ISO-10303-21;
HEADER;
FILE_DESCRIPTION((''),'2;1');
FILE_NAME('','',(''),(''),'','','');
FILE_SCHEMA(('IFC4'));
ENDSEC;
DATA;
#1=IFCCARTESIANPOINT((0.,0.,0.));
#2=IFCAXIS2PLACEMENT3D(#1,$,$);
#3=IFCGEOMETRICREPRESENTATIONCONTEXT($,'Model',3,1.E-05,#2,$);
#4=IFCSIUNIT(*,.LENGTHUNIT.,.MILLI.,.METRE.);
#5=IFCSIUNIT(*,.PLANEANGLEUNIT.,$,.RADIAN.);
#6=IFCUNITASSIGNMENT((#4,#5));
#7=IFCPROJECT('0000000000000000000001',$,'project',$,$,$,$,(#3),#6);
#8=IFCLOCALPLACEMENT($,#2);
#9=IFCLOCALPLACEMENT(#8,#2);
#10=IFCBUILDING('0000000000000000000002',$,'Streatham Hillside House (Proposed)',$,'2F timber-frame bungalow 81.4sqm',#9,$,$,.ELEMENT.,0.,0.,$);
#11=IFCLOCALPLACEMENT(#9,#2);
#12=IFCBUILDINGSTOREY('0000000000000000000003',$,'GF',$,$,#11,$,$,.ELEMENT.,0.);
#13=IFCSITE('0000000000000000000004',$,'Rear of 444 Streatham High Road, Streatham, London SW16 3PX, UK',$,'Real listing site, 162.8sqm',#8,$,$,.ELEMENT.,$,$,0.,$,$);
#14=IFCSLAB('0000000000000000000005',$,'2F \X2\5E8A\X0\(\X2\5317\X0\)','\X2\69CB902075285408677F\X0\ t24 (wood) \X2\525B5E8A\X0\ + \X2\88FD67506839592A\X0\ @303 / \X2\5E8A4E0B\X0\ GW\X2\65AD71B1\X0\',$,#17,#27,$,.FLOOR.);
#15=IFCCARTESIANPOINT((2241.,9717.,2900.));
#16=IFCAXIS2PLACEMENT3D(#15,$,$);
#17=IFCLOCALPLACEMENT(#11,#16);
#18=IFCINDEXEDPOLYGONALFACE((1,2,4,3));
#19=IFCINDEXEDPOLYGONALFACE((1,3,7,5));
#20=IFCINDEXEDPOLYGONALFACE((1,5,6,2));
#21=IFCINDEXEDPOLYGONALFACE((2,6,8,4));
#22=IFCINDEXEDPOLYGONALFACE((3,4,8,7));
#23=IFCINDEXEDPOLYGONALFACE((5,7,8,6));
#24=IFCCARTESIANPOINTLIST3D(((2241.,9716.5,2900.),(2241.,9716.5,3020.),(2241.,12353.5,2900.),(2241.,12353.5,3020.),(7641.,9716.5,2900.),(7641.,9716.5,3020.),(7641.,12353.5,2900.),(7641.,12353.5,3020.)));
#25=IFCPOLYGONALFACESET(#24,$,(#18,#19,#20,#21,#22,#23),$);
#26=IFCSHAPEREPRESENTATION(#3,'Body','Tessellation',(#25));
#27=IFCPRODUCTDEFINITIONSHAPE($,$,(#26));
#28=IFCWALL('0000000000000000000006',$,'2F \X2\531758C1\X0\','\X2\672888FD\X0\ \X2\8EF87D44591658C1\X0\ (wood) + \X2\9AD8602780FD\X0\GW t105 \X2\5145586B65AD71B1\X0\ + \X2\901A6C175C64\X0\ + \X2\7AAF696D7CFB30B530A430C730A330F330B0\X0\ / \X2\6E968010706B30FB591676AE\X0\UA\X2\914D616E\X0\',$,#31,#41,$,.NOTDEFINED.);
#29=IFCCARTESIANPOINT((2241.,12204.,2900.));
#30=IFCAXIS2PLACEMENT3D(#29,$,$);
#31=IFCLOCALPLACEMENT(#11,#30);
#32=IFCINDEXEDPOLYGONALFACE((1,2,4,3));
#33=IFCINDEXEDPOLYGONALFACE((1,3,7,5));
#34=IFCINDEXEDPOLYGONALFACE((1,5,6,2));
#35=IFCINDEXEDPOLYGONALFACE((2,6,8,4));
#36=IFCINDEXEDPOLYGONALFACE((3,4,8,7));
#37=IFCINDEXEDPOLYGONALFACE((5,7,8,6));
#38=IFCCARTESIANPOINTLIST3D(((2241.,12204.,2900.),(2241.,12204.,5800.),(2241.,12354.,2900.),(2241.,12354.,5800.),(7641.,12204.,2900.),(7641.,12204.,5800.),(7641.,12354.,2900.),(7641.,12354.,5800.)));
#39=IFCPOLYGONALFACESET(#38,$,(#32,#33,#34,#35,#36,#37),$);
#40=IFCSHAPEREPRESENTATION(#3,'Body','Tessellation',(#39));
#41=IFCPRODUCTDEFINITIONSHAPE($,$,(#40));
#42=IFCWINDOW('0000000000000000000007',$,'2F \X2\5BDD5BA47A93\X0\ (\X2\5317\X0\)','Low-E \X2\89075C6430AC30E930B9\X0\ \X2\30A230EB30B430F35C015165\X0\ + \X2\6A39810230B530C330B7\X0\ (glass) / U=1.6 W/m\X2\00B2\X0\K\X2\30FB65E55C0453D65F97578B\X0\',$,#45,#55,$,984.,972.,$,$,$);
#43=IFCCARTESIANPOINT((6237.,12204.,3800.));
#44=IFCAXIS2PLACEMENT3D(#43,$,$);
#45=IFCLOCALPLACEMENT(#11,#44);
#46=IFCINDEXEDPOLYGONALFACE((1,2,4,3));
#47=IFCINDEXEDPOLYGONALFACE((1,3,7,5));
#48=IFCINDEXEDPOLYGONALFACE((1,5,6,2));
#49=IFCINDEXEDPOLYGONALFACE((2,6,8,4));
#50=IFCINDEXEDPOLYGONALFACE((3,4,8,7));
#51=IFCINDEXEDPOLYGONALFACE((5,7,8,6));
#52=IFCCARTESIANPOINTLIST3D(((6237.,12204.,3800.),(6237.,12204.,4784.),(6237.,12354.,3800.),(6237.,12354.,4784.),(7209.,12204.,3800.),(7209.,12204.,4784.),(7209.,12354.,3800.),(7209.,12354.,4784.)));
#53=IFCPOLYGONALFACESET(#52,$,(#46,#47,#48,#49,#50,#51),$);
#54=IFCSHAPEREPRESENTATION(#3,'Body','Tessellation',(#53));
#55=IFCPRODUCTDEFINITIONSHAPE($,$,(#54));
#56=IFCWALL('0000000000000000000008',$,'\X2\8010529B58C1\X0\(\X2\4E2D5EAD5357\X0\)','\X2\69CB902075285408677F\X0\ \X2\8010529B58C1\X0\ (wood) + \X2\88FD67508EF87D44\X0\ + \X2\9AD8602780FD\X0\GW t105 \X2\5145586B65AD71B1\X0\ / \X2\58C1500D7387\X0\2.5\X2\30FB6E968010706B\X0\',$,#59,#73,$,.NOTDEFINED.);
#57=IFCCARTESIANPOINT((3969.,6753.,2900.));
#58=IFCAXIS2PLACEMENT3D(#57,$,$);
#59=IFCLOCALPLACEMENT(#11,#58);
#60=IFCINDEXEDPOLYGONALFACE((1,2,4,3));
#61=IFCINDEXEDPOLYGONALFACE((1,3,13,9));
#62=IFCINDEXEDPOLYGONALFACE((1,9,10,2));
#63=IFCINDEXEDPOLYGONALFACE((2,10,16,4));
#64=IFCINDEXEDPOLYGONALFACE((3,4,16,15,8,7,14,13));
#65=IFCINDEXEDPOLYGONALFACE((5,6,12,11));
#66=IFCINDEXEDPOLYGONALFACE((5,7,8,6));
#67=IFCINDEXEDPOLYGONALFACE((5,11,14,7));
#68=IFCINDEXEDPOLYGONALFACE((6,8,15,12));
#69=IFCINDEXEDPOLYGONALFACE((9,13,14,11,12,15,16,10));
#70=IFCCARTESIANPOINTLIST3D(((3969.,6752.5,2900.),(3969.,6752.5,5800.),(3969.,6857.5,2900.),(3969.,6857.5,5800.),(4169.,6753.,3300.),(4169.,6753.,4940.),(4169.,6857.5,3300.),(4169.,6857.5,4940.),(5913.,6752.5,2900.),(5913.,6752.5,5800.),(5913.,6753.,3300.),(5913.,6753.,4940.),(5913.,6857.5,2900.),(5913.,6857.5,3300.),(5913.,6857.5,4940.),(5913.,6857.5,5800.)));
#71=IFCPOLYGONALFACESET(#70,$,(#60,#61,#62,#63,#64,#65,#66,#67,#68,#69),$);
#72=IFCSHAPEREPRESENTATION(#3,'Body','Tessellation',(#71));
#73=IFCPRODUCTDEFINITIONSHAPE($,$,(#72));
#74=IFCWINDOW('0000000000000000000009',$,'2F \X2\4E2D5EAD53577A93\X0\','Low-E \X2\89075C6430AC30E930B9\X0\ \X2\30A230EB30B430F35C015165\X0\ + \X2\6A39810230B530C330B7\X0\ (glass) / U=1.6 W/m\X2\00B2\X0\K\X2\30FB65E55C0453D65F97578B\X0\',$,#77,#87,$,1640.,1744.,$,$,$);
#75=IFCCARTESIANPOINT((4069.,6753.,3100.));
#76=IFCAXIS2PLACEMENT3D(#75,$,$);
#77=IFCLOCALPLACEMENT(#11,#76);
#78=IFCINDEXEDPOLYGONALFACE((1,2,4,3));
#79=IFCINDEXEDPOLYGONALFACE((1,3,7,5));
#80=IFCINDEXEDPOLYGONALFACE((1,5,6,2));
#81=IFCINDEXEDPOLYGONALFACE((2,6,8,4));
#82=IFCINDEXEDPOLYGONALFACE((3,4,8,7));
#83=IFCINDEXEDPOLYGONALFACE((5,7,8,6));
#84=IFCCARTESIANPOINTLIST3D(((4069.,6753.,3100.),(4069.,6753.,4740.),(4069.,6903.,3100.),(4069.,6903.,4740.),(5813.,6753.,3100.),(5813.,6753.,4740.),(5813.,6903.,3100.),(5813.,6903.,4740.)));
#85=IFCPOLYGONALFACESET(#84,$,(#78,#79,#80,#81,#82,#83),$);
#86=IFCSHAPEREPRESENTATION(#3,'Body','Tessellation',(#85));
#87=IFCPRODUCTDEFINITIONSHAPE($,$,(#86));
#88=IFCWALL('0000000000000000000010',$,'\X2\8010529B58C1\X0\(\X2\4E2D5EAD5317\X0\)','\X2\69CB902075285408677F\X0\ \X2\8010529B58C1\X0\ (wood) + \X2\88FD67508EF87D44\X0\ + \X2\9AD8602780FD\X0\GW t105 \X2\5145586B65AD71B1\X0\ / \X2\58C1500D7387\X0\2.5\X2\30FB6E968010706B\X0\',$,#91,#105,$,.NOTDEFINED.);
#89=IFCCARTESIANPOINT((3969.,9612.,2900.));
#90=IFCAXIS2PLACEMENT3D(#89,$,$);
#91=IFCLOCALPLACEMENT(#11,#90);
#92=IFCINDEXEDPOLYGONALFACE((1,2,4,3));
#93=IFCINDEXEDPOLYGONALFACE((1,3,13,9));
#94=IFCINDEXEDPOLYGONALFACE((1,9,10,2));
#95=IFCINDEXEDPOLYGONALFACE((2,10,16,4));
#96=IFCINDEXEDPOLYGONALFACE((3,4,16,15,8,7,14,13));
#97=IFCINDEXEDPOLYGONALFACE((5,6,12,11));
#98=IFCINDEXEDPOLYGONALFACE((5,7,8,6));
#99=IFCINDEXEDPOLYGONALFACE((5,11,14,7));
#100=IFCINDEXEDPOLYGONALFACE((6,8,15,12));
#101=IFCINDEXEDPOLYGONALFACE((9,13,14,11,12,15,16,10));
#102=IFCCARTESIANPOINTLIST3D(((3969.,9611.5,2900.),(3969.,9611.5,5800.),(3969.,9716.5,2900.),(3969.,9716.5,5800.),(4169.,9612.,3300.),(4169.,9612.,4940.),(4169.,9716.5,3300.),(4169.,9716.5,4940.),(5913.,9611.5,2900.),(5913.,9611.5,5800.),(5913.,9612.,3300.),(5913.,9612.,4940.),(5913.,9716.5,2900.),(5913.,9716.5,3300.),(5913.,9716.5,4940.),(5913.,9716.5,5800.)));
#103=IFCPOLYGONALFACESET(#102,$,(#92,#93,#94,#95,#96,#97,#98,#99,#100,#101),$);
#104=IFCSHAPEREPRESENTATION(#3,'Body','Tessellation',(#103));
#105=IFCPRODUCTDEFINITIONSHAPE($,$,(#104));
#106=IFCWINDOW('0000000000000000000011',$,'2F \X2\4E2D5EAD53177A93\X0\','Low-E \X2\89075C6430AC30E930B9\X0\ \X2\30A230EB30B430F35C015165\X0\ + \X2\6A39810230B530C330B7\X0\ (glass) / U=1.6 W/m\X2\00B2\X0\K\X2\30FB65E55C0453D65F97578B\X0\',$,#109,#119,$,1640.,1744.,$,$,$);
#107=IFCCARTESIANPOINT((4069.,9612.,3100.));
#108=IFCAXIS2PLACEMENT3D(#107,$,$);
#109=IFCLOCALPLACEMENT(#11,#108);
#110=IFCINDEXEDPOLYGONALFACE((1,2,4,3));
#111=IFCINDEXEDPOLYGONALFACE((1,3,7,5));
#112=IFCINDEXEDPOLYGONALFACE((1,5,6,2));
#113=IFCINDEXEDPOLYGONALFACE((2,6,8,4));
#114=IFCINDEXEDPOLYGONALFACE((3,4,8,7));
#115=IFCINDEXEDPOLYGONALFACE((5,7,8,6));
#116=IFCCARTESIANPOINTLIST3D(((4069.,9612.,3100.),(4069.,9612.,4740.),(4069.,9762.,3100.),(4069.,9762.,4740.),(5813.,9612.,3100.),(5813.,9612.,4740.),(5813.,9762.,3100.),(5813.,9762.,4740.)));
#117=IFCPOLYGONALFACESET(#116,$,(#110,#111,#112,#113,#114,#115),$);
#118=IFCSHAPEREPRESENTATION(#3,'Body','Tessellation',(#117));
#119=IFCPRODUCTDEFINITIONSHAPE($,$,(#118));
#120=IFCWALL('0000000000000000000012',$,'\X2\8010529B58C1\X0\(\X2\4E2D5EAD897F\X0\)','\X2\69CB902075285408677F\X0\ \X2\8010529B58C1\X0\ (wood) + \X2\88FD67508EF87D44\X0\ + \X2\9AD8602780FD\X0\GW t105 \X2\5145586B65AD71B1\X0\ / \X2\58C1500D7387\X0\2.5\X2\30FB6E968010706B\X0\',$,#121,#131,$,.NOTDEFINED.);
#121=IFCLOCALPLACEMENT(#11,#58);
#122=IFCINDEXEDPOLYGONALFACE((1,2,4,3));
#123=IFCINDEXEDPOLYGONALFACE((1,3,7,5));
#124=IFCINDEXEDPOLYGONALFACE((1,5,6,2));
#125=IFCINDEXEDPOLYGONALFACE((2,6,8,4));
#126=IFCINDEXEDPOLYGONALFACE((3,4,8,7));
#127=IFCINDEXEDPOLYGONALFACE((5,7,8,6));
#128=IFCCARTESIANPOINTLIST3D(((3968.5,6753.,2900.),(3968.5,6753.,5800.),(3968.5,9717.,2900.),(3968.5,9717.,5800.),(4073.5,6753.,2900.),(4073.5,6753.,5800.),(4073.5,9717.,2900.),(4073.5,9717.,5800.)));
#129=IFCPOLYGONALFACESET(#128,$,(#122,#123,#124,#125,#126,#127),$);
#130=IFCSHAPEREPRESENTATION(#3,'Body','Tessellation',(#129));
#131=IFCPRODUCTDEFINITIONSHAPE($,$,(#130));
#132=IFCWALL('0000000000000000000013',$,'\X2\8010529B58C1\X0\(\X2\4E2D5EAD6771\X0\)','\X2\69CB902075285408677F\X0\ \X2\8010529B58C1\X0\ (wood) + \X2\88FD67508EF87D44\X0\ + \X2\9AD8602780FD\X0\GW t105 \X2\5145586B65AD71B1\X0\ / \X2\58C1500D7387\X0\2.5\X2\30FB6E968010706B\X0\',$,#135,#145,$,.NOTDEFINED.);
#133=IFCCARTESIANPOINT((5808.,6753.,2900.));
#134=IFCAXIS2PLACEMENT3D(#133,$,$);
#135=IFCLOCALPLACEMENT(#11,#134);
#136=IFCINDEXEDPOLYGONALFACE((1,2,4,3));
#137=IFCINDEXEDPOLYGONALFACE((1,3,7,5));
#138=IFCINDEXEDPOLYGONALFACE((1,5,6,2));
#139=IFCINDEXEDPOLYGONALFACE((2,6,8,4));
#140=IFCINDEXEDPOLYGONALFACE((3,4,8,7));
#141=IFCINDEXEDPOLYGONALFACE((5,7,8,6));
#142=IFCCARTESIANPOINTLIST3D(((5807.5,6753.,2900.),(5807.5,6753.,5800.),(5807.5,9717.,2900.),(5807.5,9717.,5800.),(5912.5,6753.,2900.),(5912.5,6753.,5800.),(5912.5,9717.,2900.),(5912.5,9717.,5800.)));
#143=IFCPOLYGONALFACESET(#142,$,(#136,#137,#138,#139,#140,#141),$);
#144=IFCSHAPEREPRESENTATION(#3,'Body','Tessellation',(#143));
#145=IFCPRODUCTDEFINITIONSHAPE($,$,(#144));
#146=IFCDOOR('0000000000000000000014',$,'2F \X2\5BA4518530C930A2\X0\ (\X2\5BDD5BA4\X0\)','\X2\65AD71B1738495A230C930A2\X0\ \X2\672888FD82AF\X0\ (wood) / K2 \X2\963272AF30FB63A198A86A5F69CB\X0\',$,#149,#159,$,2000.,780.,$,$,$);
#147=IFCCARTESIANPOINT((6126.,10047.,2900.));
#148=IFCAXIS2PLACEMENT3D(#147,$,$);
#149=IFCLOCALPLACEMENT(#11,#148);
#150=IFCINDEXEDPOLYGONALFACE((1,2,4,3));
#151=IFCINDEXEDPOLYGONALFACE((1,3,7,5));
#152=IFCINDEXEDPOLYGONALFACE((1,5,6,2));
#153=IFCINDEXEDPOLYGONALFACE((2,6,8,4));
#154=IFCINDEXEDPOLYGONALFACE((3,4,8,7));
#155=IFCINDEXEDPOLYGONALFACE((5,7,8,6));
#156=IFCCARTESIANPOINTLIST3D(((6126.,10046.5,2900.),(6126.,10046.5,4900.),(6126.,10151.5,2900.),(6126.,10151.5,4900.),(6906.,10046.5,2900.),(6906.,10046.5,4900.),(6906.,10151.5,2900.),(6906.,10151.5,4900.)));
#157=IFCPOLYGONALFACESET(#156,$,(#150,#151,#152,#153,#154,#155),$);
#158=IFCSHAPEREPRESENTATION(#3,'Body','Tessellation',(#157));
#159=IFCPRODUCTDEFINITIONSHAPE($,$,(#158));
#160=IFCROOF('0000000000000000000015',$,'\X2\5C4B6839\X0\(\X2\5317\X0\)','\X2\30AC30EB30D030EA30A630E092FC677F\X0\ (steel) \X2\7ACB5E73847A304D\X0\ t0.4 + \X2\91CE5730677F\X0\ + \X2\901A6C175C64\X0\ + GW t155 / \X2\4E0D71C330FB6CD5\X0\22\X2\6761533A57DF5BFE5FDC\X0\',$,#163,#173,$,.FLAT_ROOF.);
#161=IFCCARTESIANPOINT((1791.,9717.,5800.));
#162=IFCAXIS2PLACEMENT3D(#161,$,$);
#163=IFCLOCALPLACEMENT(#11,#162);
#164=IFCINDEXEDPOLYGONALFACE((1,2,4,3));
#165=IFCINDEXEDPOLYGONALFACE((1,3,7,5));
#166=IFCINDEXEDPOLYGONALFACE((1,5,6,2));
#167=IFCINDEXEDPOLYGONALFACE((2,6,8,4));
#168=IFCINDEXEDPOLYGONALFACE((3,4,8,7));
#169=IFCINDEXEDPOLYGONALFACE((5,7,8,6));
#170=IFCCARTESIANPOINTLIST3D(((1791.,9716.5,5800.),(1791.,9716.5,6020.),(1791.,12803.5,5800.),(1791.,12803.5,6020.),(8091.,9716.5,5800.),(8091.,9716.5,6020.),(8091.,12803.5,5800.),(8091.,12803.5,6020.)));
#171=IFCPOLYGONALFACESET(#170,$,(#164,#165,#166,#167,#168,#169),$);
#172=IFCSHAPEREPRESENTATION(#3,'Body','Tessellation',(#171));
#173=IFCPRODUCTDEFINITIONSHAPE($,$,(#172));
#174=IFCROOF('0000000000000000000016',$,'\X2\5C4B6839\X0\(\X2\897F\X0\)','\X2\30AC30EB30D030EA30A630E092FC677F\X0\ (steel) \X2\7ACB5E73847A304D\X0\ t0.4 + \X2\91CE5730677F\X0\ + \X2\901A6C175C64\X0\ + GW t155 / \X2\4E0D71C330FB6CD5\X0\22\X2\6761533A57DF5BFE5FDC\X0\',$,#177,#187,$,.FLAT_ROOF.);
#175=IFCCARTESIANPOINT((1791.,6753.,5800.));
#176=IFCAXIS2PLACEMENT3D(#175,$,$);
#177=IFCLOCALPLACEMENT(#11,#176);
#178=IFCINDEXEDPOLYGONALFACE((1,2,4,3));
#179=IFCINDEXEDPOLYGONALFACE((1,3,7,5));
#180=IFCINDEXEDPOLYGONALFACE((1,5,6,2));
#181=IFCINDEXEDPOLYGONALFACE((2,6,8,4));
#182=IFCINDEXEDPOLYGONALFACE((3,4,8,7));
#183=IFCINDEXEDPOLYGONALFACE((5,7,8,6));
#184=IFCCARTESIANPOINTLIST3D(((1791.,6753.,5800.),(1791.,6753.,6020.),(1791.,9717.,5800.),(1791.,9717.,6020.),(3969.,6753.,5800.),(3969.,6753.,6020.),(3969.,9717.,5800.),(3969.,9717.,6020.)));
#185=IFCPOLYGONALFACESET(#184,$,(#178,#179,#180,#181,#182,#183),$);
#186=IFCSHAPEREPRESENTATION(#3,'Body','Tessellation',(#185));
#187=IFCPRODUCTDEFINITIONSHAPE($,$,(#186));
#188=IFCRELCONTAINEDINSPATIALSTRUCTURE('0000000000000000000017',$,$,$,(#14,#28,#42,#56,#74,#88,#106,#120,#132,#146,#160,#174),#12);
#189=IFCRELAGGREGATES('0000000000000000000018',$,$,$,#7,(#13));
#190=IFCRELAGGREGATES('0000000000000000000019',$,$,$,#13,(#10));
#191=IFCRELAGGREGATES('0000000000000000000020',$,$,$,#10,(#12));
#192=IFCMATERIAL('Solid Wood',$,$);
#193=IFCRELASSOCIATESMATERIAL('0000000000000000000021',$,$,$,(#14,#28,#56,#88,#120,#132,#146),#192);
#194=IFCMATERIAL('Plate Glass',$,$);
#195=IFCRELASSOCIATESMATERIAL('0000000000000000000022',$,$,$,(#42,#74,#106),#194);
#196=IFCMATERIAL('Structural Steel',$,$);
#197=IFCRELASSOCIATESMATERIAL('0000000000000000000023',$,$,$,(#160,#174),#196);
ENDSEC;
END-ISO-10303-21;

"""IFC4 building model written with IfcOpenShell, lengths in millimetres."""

from ifc_helpers import new_model, si_unit, frame, frame_2d, origin, place, context, project, spatial, rectangle, extrude, material, element, fill, save


model = new_model("IFC4")

# Units and contexts
model_context = context("Model", 3, precision=1e-05, world=origin())
ifc_project = project(units=[si_unit("LENGTHUNIT", "METRE", prefix="MILLI"), si_unit("PLANEANGLEUNIT", "RADIAN")], contexts=[model_context])

# Site, building, storey
site_placement = place(None, origin())
site = spatial("IfcSite", under=ifc_project, at=site_placement, Name="Rear of 444 Streatham High Road, Streatham, London SW16 3PX, UK", ObjectType="Real listing site, 162.8sqm", CompositionType="ELEMENT", RefElevation=0.0)
building_placement = place(site_placement, origin())
building = spatial("IfcBuilding", under=site, at=building_placement, Name="Streatham Hillside House (Proposed)", ObjectType="2F timber-frame bungalow 81.4sqm", CompositionType="ELEMENT", ElevationOfRefHeight=0.0, ElevationOfTerrain=0.0)
storey_placement = place(building_placement, origin())
storey = spatial("IfcBuildingStorey", under=building, at=storey_placement, Name="GF", CompositionType="ELEMENT", Elevation=0.0)

# Slab
ifc_material_1 = material(Name="Solid Wood")
slab_placement = place(storey_placement, frame((2241.0, 9717.0, 2900.0)))
element("IfcSlab", 1, at=slab_placement, inside=storey, material=ifc_material_1, Name="2F 床(北)", Description="構造用合板 t24 (wood) 剛床 + 製材根太 @303 / 床下 GW断熱", PredefinedType="FLOOR", context=model_context, shape_type="SweptSolid", body=[
    extrude(rectangle(XDim=5400.0, YDim=2637.0, at=frame_2d((2700.0, 1318.0))), frame((2241.0, 9717.0, 2900.0)), (0.0, 0.0, 1.0), 120.0),
])

# Walls, openings, windows
wall_1_placement = place(storey_placement, frame((2241.0, 12204.0, 2900.0)))
wall_1 = element("IfcWall", 2, at=wall_1_placement, inside=storey, material=ifc_material_1, Name="2F 北壁", Description="木製 軸組外壁 (wood) + 高性能GW t105 充填断熱 + 通気層 + 窯業系サイディング / 準耐火・外皮UA配慮", PredefinedType="NOTDEFINED", context=model_context, shape_type="SweptSolid", body=[
    extrude(rectangle(XDim=5400.0, YDim=150.0, at=frame_2d((2700.0, 75.0))), frame((2241.0, 12204.0, 2900.0)), (0.0, 0.0, 1.0), 2900.0),
])
opening_1_placement = place(storey_placement, frame((6237.0, 12204.0, 3800.0)))
opening_1 = element("IfcOpeningElement", 3, at=opening_1_placement, cuts=wall_1, PredefinedType="NOTDEFINED", context=model_context, shape_type="SweptSolid", body=[
    extrude(rectangle(XDim=972.0, YDim=150.0, at=frame_2d((486.0, 75.0))), frame((6237.0, 12204.0, 3800.0)), (0.0, 0.0, 1.0), 984.0),
])
ifc_material_2 = material(Name="Plate Glass")
window_1_placement = place(storey_placement, frame((6237.0, 12204.0, 3800.0)))
window_1 = element("IfcWindow", 4, at=window_1_placement, inside=storey, material=ifc_material_2, Name="2F 寝室窓 (北)", Description="Low-E 複層ガラス アルゴン封入 + 樹脂サッシ (glass) / U=1.6 W/m²K・日射取得型", OverallHeight=984.0, OverallWidth=972.0, context=model_context, shape_type="SweptSolid", body=[
    extrude(rectangle(XDim=972.0, YDim=150.0, at=frame_2d((486.0, 75.0))), frame((6237.0, 12204.0, 3800.0)), (0.0, 0.0, 1.0), 984.0),
])
fill(opening_1, window_1)
wall_2_placement = place(storey_placement, frame((3969.0, 6753.0, 2900.0)))
wall_2 = element("IfcWall", 5, at=wall_2_placement, inside=storey, material=ifc_material_1, Name="耐力壁(中庭南)", Description="構造用合板 耐力壁 (wood) + 製材軸組 + 高性能GW t105 充填断熱 / 壁倍率2.5・準耐火", PredefinedType="NOTDEFINED", context=model_context, shape_type="SweptSolid", body=[
    extrude(rectangle(XDim=1944.0, YDim=105.0, at=frame_2d((972.0, 52.0))), frame((3969.0, 6753.0, 2900.0)), (0.0, 0.0, 1.0), 2900.0),
])
opening_2_placement = place(storey_placement, frame((4069.0, 6753.0, 3100.0)))
opening_2 = element("IfcOpeningElement", 6, at=opening_2_placement, cuts=wall_2, PredefinedType="NOTDEFINED", context=model_context, shape_type="SweptSolid", body=[
    extrude(rectangle(XDim=1744.0, YDim=150.0, at=frame_2d((872.0, 75.0))), frame((4069.0, 6753.0, 3100.0)), (0.0, 0.0, 1.0), 1640.0),
])
window_2_placement = place(storey_placement, frame((4069.0, 6753.0, 3100.0)))
window_2 = element("IfcWindow", 7, at=window_2_placement, inside=storey, material=ifc_material_2, Name="2F 中庭南窓", Description="Low-E 複層ガラス アルゴン封入 + 樹脂サッシ (glass) / U=1.6 W/m²K・日射取得型", OverallHeight=1640.0, OverallWidth=1744.0, context=model_context, shape_type="SweptSolid", body=[
    extrude(rectangle(XDim=1744.0, YDim=150.0, at=frame_2d((872.0, 75.0))), frame((4069.0, 6753.0, 3100.0)), (0.0, 0.0, 1.0), 1640.0),
])
fill(opening_2, window_2)
wall_3_placement = place(storey_placement, frame((3969.0, 9612.0, 2900.0)))
wall_3 = element("IfcWall", 8, at=wall_3_placement, inside=storey, material=ifc_material_1, Name="耐力壁(中庭北)", Description="構造用合板 耐力壁 (wood) + 製材軸組 + 高性能GW t105 充填断熱 / 壁倍率2.5・準耐火", PredefinedType="NOTDEFINED", context=model_context, shape_type="SweptSolid", body=[
    extrude(rectangle(XDim=1944.0, YDim=105.0, at=frame_2d((972.0, 52.0))), frame((3969.0, 9612.0, 2900.0)), (0.0, 0.0, 1.0), 2900.0),
])
opening_3_placement = place(storey_placement, frame((4069.0, 9612.0, 3100.0)))
opening_3 = element("IfcOpeningElement", 9, at=opening_3_placement, cuts=wall_3, PredefinedType="NOTDEFINED", context=model_context, shape_type="SweptSolid", body=[
    extrude(rectangle(XDim=1744.0, YDim=150.0, at=frame_2d((872.0, 75.0))), frame((4069.0, 9612.0, 3100.0)), (0.0, 0.0, 1.0), 1640.0),
])
window_3_placement = place(storey_placement, frame((4069.0, 9612.0, 3100.0)))
window_3 = element("IfcWindow", 10, at=window_3_placement, inside=storey, material=ifc_material_2, Name="2F 中庭北窓", Description="Low-E 複層ガラス アルゴン封入 + 樹脂サッシ (glass) / U=1.6 W/m²K・日射取得型", OverallHeight=1640.0, OverallWidth=1744.0, context=model_context, shape_type="SweptSolid", body=[
    extrude(rectangle(XDim=1744.0, YDim=150.0, at=frame_2d((872.0, 75.0))), frame((4069.0, 9612.0, 3100.0)), (0.0, 0.0, 1.0), 1640.0),
])
fill(opening_3, window_3)

# Walls
wall_4_placement = place(storey_placement, frame((3969.0, 6753.0, 2900.0)))
element("IfcWall", 11, at=wall_4_placement, inside=storey, material=ifc_material_1, Name="耐力壁(中庭西)", Description="構造用合板 耐力壁 (wood) + 製材軸組 + 高性能GW t105 充填断熱 / 壁倍率2.5・準耐火", PredefinedType="NOTDEFINED", context=model_context, shape_type="SweptSolid", body=[
    extrude(rectangle(XDim=105.0, YDim=2964.0, at=frame_2d((52.0, 1482.0))), frame((3969.0, 6753.0, 2900.0)), (0.0, 0.0, 1.0), 2900.0),
])
wall_5_placement = place(storey_placement, frame((5808.0, 6753.0, 2900.0)))
element("IfcWall", 12, at=wall_5_placement, inside=storey, material=ifc_material_1, Name="耐力壁(中庭東)", Description="構造用合板 耐力壁 (wood) + 製材軸組 + 高性能GW t105 充填断熱 / 壁倍率2.5・準耐火", PredefinedType="NOTDEFINED", context=model_context, shape_type="SweptSolid", body=[
    extrude(rectangle(XDim=105.0, YDim=2964.0, at=frame_2d((52.0, 1482.0))), frame((5808.0, 6753.0, 2900.0)), (0.0, 0.0, 1.0), 2900.0),
])

# Door
door_placement = place(storey_placement, frame((6126.0, 10047.0, 2900.0)))
element("IfcDoor", 13, at=door_placement, inside=storey, material=ifc_material_1, Name="2F 室内ドア (寝室)", Description="断熱玄関ドア 木製芯 (wood) / K2 防犯・採風機構", OverallHeight=2000.0, OverallWidth=780.0, context=model_context, shape_type="SweptSolid", body=[
    extrude(rectangle(XDim=780.0, YDim=105.0, at=frame_2d((390.0, 52.0))), frame((6126.0, 10047.0, 2900.0)), (0.0, 0.0, 1.0), 2000.0),
])

# Roofs
ifc_material_3 = material(Name="Structural Steel")
for number, where, name in (
    (14, (1791.0, 9717.0, 5800.0), "屋根(北)"),
):
    element("IfcRoof", number, at=place(storey_placement, frame(where)), inside=storey, material=ifc_material_3, Name=name, Description="ガルバリウム鋼板 (steel) 立平葺き t0.4 + 野地板 + 通気層 + GW t155 / 不燃・法22条区域対応", PredefinedType="FLAT_ROOF", context=model_context, shape_type="SweptSolid", body=[
        extrude(rectangle(XDim=6300.0, YDim=3087.0, at=frame_2d((3150.0, 1543.0))), frame((1791.0, 9717.0, 5800.0)), (0.0, 0.0, 1.0), 220.0),
    ])
roof_1_placement = place(storey_placement, frame((1791.0, 6753.0, 5800.0)))
element("IfcRoof", 15, at=roof_1_placement, inside=storey, material=ifc_material_3, Name="屋根(西)", Description="ガルバリウム鋼板 (steel) 立平葺き t0.4 + 野地板 + 通気層 + GW t155 / 不燃・法22条区域対応", PredefinedType="FLAT_ROOF", context=model_context, shape_type="SweptSolid", body=[
    extrude(rectangle(XDim=2178.0, YDim=2964.0, at=frame_2d((1089.0, 1482.0))), frame((1791.0, 6753.0, 5800.0)), (0.0, 0.0, 1.0), 220.0),
])

save(model, "model.ifc")
